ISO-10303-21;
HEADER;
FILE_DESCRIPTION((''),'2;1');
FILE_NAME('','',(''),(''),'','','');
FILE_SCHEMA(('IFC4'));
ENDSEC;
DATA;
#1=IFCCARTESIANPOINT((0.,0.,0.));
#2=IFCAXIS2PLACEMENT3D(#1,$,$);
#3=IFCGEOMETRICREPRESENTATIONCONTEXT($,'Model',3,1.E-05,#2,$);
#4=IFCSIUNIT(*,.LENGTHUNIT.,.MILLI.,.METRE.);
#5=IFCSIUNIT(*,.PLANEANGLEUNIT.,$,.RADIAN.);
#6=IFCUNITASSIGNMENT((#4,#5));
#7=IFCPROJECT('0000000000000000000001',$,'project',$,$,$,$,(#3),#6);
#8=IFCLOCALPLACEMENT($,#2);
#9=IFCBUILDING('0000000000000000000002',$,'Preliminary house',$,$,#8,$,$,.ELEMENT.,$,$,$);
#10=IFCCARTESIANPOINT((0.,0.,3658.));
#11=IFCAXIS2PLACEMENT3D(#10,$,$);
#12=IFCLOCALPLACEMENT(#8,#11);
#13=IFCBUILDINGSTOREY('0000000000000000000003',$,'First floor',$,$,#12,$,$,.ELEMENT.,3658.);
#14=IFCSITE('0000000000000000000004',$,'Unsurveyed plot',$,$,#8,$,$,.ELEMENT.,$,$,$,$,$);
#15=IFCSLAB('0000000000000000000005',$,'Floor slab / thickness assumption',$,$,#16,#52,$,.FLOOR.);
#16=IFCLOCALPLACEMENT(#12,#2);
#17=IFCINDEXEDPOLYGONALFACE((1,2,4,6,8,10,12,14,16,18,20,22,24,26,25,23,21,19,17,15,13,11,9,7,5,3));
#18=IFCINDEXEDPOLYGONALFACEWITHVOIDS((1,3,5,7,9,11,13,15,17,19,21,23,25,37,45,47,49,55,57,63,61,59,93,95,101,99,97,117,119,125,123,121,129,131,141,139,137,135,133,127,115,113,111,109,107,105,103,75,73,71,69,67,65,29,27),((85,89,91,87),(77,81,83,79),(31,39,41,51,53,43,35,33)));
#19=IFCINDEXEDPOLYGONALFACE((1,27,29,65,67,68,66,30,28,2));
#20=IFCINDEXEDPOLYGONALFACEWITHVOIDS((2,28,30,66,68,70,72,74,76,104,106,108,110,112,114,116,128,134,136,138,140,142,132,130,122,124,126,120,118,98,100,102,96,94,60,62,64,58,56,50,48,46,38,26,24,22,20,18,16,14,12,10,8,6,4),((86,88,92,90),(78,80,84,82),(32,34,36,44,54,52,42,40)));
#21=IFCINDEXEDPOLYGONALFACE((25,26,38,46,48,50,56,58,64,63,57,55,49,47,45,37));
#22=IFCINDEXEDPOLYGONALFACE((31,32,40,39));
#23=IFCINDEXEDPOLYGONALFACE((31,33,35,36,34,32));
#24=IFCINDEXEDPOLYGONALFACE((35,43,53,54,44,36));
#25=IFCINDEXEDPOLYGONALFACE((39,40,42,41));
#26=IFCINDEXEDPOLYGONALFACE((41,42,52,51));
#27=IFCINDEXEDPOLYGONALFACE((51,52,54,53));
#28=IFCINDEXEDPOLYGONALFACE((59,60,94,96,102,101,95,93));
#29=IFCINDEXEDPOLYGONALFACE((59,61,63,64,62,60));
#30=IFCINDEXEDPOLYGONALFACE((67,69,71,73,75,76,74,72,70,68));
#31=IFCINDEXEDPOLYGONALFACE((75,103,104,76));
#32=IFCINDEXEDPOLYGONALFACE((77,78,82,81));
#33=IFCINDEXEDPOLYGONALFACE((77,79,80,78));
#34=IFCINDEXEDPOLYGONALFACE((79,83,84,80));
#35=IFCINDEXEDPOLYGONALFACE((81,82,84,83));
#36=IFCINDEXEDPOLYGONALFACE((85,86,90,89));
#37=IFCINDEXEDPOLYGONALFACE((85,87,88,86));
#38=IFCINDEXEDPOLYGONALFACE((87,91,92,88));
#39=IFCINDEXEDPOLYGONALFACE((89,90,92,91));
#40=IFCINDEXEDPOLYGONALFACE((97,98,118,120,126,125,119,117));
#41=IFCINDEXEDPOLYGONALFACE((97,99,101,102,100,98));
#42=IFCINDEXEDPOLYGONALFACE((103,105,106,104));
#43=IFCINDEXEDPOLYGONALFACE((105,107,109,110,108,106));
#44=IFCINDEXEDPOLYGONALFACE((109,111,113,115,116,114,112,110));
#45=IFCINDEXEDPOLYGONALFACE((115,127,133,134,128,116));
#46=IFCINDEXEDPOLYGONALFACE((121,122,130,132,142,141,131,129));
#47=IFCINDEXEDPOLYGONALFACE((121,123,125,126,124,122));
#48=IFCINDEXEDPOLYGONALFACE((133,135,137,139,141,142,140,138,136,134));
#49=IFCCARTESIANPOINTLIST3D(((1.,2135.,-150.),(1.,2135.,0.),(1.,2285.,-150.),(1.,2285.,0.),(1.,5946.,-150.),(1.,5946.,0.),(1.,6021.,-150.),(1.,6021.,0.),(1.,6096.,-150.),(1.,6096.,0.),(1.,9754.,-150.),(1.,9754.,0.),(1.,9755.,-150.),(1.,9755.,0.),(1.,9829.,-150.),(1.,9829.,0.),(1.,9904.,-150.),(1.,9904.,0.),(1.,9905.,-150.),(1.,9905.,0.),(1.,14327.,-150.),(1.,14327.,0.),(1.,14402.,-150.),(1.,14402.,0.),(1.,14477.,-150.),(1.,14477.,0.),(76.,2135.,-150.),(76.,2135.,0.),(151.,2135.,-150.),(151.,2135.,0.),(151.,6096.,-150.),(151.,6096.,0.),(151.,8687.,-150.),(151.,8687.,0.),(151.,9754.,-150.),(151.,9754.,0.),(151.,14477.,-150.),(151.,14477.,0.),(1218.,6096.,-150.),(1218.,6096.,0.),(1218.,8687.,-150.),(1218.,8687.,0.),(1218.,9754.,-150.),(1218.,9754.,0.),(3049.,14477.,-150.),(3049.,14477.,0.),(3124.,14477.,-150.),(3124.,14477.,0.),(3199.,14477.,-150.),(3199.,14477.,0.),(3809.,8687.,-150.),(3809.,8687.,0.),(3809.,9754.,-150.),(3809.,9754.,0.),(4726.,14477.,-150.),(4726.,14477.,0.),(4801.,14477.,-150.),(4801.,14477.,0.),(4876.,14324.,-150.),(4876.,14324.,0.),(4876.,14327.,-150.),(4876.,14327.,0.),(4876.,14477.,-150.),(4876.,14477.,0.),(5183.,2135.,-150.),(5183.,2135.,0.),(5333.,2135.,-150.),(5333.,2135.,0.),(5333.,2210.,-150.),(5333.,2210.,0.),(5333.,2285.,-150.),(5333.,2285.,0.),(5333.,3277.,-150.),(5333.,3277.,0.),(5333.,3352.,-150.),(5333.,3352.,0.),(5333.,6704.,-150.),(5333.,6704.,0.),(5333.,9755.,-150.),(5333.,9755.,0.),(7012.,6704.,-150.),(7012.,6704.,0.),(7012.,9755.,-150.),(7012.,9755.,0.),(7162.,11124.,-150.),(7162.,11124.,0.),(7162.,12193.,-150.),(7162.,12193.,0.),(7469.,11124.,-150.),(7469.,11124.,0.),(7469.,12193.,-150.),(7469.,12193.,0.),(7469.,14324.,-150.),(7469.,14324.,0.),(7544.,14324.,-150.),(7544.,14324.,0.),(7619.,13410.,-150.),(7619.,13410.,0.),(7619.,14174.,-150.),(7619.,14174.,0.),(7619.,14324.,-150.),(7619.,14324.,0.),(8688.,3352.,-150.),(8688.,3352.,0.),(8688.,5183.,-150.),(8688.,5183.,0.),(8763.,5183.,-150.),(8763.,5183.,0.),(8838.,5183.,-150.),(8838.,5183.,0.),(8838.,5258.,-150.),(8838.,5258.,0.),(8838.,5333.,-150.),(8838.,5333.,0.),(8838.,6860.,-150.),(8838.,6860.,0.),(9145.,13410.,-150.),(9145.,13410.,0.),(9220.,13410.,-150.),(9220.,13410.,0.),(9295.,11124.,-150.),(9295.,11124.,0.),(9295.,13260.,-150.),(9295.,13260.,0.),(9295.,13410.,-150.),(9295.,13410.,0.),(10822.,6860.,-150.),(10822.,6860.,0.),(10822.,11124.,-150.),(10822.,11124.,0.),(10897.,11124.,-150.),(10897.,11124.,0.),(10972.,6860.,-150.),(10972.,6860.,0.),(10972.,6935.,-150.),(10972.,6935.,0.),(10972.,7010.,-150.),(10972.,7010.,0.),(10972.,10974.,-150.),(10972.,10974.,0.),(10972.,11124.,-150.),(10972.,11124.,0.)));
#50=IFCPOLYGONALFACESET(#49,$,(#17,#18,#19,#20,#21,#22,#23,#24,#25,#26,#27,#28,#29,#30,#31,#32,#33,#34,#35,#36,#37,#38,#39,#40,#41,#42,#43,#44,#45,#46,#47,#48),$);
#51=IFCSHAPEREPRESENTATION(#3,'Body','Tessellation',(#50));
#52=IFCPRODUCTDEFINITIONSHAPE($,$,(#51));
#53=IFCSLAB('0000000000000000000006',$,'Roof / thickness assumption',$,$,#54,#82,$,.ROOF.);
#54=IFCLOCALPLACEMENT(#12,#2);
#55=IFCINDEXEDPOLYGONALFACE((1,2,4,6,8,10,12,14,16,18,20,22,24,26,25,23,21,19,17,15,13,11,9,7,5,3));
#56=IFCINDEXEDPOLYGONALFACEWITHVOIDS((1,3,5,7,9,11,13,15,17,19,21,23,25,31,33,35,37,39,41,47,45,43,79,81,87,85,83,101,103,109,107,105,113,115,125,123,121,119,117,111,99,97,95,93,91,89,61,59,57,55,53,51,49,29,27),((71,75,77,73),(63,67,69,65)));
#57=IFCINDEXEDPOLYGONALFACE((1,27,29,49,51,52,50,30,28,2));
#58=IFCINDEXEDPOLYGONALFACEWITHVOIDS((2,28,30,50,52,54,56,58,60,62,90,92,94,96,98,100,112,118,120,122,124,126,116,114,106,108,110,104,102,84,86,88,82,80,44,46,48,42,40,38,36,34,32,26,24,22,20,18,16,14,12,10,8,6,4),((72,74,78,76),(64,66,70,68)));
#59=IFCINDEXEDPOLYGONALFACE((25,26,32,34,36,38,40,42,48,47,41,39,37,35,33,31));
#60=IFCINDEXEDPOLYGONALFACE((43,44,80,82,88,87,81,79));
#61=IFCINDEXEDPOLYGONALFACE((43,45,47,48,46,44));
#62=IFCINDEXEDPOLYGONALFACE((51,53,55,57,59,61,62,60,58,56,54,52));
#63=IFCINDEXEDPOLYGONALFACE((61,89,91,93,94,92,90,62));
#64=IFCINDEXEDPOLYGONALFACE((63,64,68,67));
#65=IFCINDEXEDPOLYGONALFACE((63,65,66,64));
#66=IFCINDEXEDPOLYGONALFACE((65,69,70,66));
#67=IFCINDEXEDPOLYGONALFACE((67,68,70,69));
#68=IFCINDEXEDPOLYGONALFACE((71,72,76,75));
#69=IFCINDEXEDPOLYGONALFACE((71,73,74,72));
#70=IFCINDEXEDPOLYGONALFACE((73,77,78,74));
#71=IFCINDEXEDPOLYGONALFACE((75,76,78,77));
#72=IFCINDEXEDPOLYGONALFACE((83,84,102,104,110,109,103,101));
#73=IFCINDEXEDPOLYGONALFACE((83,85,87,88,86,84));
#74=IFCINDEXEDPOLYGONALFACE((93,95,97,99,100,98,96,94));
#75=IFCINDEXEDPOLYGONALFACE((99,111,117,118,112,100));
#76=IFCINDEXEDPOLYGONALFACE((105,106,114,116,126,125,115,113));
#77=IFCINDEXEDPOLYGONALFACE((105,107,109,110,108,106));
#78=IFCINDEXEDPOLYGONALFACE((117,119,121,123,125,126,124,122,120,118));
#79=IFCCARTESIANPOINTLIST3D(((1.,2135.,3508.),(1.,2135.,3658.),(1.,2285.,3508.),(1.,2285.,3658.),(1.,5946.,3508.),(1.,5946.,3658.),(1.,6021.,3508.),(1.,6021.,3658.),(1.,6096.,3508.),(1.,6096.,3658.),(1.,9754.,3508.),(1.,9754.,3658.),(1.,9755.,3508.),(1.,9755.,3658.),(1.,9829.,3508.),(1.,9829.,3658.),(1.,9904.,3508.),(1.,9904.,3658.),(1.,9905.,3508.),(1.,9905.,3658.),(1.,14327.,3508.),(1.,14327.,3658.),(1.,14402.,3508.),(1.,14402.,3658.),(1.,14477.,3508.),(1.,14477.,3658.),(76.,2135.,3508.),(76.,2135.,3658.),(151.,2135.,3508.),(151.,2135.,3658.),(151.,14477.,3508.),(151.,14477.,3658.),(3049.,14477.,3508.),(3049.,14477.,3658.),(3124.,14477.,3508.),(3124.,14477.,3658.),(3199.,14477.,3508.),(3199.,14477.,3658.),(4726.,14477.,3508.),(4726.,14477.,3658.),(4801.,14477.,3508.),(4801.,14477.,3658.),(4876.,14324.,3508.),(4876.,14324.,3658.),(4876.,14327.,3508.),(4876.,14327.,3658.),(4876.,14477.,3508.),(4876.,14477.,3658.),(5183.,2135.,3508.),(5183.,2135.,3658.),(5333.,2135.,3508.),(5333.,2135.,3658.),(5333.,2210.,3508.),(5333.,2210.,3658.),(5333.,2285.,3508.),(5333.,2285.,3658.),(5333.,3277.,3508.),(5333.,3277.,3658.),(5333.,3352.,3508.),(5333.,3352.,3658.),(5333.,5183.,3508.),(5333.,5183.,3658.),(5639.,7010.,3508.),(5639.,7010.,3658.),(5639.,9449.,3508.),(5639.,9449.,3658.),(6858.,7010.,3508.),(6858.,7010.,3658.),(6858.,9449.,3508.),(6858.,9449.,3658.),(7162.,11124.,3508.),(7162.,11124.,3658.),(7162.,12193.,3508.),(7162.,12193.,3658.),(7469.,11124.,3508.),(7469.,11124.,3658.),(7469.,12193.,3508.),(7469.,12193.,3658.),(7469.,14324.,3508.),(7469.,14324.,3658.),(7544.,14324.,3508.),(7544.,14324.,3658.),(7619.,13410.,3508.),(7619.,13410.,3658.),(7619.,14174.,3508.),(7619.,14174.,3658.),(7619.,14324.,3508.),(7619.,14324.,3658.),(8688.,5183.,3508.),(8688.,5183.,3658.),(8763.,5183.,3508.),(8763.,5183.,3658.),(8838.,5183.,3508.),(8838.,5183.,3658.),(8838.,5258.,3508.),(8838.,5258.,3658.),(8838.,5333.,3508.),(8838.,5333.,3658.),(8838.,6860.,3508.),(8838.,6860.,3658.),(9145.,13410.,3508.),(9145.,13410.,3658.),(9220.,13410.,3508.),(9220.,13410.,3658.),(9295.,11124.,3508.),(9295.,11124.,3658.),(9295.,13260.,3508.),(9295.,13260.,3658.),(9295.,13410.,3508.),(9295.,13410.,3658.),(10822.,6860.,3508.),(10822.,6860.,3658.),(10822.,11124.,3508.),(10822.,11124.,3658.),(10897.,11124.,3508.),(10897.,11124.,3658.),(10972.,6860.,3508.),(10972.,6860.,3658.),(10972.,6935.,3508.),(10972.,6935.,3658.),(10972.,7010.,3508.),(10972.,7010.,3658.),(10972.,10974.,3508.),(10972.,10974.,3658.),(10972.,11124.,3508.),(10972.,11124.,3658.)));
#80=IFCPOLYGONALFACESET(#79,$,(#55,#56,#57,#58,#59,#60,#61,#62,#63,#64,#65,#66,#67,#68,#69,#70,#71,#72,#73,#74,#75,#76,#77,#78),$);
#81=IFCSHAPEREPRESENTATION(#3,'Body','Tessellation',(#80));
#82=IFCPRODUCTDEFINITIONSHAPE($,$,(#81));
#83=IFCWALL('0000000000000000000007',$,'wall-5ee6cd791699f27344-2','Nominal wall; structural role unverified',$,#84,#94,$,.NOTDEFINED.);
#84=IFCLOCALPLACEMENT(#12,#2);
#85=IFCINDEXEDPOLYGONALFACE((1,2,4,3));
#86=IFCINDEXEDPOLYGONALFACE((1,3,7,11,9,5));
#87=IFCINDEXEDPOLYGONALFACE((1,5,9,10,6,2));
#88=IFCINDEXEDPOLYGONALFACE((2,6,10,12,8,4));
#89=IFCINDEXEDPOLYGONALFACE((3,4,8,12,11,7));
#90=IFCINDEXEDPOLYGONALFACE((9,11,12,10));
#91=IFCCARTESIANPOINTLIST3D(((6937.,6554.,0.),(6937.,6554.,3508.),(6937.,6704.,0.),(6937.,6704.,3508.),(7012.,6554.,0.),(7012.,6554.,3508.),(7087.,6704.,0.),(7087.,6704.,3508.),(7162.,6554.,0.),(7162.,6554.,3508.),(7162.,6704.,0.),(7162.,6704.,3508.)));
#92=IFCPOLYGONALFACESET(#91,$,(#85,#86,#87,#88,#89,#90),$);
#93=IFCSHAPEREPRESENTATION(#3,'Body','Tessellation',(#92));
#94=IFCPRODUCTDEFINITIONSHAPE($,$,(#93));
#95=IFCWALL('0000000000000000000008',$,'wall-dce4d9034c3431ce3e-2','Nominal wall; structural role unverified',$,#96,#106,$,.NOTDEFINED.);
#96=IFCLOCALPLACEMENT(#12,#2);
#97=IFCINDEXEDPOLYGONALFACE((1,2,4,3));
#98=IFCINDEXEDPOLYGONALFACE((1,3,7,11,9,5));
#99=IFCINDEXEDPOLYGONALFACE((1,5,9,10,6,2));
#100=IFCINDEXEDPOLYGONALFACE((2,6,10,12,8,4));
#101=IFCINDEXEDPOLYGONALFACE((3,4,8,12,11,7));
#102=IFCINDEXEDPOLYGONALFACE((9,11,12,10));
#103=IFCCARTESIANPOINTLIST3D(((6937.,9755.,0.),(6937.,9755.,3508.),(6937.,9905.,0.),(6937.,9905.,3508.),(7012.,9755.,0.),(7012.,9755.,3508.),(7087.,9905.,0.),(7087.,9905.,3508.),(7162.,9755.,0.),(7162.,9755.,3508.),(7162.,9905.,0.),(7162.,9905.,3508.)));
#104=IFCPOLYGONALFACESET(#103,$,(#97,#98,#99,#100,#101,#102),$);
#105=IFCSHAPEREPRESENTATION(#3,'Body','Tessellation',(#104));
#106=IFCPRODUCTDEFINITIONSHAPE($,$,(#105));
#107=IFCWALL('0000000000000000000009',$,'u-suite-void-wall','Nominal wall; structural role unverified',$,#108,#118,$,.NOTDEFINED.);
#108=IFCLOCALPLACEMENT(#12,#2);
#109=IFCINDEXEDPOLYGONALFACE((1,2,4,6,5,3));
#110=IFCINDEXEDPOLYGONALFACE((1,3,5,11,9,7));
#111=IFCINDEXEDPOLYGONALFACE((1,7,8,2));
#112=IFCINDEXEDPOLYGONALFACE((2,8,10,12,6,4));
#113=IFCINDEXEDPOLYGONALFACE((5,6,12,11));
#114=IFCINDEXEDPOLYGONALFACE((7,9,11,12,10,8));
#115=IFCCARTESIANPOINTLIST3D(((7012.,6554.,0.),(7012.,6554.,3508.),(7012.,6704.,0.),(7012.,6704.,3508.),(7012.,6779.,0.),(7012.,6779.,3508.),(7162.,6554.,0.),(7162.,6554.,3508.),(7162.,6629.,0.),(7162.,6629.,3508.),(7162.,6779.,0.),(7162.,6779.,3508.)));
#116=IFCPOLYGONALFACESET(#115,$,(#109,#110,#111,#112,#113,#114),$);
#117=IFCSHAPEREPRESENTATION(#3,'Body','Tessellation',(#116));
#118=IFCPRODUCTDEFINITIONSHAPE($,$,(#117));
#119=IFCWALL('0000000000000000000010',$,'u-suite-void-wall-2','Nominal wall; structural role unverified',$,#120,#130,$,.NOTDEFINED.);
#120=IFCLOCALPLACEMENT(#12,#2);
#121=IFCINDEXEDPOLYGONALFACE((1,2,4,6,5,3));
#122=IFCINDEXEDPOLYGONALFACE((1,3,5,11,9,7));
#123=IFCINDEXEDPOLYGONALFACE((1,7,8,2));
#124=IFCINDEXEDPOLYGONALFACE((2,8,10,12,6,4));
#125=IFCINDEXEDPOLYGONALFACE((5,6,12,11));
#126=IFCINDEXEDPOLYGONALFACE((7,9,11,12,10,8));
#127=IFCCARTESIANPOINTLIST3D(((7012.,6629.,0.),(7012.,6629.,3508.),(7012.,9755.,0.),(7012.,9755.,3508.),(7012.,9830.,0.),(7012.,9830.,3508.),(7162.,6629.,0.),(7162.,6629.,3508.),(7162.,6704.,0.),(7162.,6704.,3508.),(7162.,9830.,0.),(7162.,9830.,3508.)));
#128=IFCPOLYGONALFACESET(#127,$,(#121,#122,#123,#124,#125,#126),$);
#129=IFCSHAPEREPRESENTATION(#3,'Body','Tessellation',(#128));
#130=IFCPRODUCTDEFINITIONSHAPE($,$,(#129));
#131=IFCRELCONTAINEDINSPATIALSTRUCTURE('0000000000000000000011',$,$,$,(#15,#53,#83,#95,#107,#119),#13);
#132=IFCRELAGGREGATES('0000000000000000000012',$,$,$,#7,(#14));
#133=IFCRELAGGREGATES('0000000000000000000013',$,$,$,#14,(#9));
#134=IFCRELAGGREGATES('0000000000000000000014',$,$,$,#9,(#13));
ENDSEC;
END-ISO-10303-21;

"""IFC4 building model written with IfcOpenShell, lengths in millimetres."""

from ifc_helpers import new_model, si_unit, frame, origin, place, context, project, spatial, polyline, outline, extrude, element, save


model = new_model("IFC4")

# Units and contexts
model_context = context("Model", 3, precision=1e-05, world=origin())
ifc_project = project(units=[si_unit("LENGTHUNIT", "METRE", prefix="MILLI"), si_unit("PLANEANGLEUNIT", "RADIAN")], contexts=[model_context])

# Site, building, storey
placement_1 = place(None, origin())
site = spatial("IfcSite", under=ifc_project, at=placement_1, Name="Unsurveyed plot", CompositionType="ELEMENT")
building = spatial("IfcBuilding", under=site, at=placement_1, Name="Preliminary house", CompositionType="ELEMENT")
placement_2 = place(placement_1, frame((0.0, 0.0, 3658.0)))
storey = spatial("IfcBuildingStorey", under=building, at=placement_2, Name="First floor", CompositionType="ELEMENT", Elevation=3658.0)

# Slabs
element("IfcSlab", 1, at=placement_2, inside=storey, Name="Floor slab / thickness assumption", PredefinedType="FLOOR", context=model_context, shape_type="SweptSolid", body=[
    extrude(outline(polyline([(1.0, 5946.0), (1.0, 6021.0), (1.0, 6096.0), (1.0, 9754.0), (1.0, 9755.0), (1.0, 9829.0), (1.0, 9904.0), (1.0, 9905.0), (1.0, 14327.0), (1.0, 14402.0), (1.0, 14477.0), (151.0, 14477.0), (3049.0, 14477.0), (3124.0, 14477.0), (3199.0, 14477.0), (4726.0, 14477.0), (4801.0, 14477.0), (4876.0, 14477.0), (4876.0, 14327.0), (4876.0, 14324.0), (7469.0, 14324.0), (7544.0, 14324.0), (7619.0, 14324.0), (7619.0, 14174.0), (7619.0, 13410.0), (9145.0, 13410.0), (9220.0, 13410.0), (9295.0, 13410.0), (9295.0, 13260.0), (9295.0, 11124.0), (10822.0, 11124.0), (10897.0, 11124.0), (10972.0, 11124.0), (10972.0, 10974.0), (10972.0, 7010.0), (10972.0, 6935.0), (10972.0, 6860.0), (10822.0, 6860.0), (8838.0, 6860.0), (8838.0, 5333.0), (8838.0, 5258.0), (8838.0, 5183.0), (8763.0, 5183.0), (8688.0, 5183.0), (8688.0, 3352.0), (5333.0, 3352.0), (5333.0, 3277.0), (5333.0, 2285.0), (5333.0, 2210.0), (5333.0, 2135.0), (5183.0, 2135.0), (151.0, 2135.0), (76.0, 2135.0), (1.0, 2135.0), (1.0, 2285.0), (1.0, 5946.0)]), holes=[polyline([(7469.0, 11124.0), (7469.0, 12193.0), (7162.0, 12193.0), (7162.0, 11124.0), (7469.0, 11124.0)]), polyline([(5333.0, 9755.0), (5333.0, 6704.0), (7012.0, 6704.0), (7012.0, 9755.0), (5333.0, 9755.0)]), polyline([(1218.0, 8687.0), (3809.0, 8687.0), (3809.0, 9754.0), (1218.0, 9754.0), (151.0, 9754.0), (151.0, 8687.0), (151.0, 6096.0), (1218.0, 6096.0), (1218.0, 8687.0)])]), frame((0.0, 0.0, -150.0)), (0.0, 0.0, 1.0), 150.0),
])
element("IfcSlab", 2, at=placement_2, inside=storey, Name="Roof / thickness assumption", PredefinedType="ROOF", context=model_context, shape_type="SweptSolid", body=[
    extrude(outline(polyline([(1.0, 5946.0), (1.0, 6021.0), (1.0, 6096.0), (1.0, 9754.0), (1.0, 9755.0), (1.0, 9829.0), (1.0, 9904.0), (1.0, 9905.0), (1.0, 14327.0), (1.0, 14402.0), (1.0, 14477.0), (151.0, 14477.0), (3049.0, 14477.0), (3124.0, 14477.0), (3199.0, 14477.0), (4726.0, 14477.0), (4801.0, 14477.0), (4876.0, 14477.0), (4876.0, 14327.0), (4876.0, 14324.0), (7469.0, 14324.0), (7544.0, 14324.0), (7619.0, 14324.0), (7619.0, 14174.0), (7619.0, 13410.0), (9145.0, 13410.0), (9220.0, 13410.0), (9295.0, 13410.0), (9295.0, 13260.0), (9295.0, 11124.0), (10822.0, 11124.0), (10897.0, 11124.0), (10972.0, 11124.0), (10972.0, 10974.0), (10972.0, 7010.0), (10972.0, 6935.0), (10972.0, 6860.0), (10822.0, 6860.0), (8838.0, 6860.0), (8838.0, 5333.0), (8838.0, 5258.0), (8838.0, 5183.0), (8763.0, 5183.0), (8688.0, 5183.0), (5333.0, 5183.0), (5333.0, 3352.0), (5333.0, 3277.0), (5333.0, 2285.0), (5333.0, 2210.0), (5333.0, 2135.0), (5183.0, 2135.0), (151.0, 2135.0), (76.0, 2135.0), (1.0, 2135.0), (1.0, 2285.0), (1.0, 5946.0)]), holes=[polyline([(7469.0, 11124.0), (7469.0, 12193.0), (7162.0, 12193.0), (7162.0, 11124.0), (7469.0, 11124.0)]), polyline([(6858.0, 7010.0), (6858.0, 9449.0), (5639.0, 9449.0), (5639.0, 7010.0), (6858.0, 7010.0)])]), frame((0.0, 0.0, 3508.0)), (0.0, 0.0, 1.0), 150.0),
])

# Walls
element("IfcWall", 3, at=placement_2, inside=storey, Name="wall-5ee6cd791699f27344-2", Description="Nominal wall; structural role unverified", PredefinedType="NOTDEFINED", context=model_context, shape_type="SweptSolid", body=[
    extrude(outline(polyline([(7087.0, 6704.0), (7162.0, 6704.0), (7162.0, 6554.0), (7012.0, 6554.0), (6937.0, 6554.0), (6937.0, 6704.0), (7087.0, 6704.0)])), origin(), (0.0, 0.0, 1.0), 3508.0),
])
element("IfcWall", 4, at=placement_2, inside=storey, Name="wall-dce4d9034c3431ce3e-2", Description="Nominal wall; structural role unverified", PredefinedType="NOTDEFINED", context=model_context, shape_type="SweptSolid", body=[
    extrude(outline(polyline([(7087.0, 9905.0), (7162.0, 9905.0), (7162.0, 9755.0), (7012.0, 9755.0), (6937.0, 9755.0), (6937.0, 9905.0), (7087.0, 9905.0)])), origin(), (0.0, 0.0, 1.0), 3508.0),
])
element("IfcWall", 5, at=placement_2, inside=storey, Name="u-suite-void-wall", Description="Nominal wall; structural role unverified", PredefinedType="NOTDEFINED", context=model_context, shape_type="SweptSolid", body=[
    extrude(outline(polyline([(7012.0, 6704.0), (7012.0, 6779.0), (7162.0, 6779.0), (7162.0, 6629.0), (7162.0, 6554.0), (7012.0, 6554.0), (7012.0, 6704.0)])), origin(), (0.0, 0.0, 1.0), 3508.0),
])
element("IfcWall", 6, at=placement_2, inside=storey, Name="u-suite-void-wall-2", Description="Nominal wall; structural role unverified", PredefinedType="NOTDEFINED", context=model_context, shape_type="SweptSolid", body=[
    extrude(outline(polyline([(7012.0, 9755.0), (7012.0, 9830.0), (7162.0, 9830.0), (7162.0, 6704.0), (7162.0, 6629.0), (7012.0, 6629.0), (7012.0, 9755.0)])), origin(), (0.0, 0.0, 1.0), 3508.0),
])

save(model, "model.ifc")
